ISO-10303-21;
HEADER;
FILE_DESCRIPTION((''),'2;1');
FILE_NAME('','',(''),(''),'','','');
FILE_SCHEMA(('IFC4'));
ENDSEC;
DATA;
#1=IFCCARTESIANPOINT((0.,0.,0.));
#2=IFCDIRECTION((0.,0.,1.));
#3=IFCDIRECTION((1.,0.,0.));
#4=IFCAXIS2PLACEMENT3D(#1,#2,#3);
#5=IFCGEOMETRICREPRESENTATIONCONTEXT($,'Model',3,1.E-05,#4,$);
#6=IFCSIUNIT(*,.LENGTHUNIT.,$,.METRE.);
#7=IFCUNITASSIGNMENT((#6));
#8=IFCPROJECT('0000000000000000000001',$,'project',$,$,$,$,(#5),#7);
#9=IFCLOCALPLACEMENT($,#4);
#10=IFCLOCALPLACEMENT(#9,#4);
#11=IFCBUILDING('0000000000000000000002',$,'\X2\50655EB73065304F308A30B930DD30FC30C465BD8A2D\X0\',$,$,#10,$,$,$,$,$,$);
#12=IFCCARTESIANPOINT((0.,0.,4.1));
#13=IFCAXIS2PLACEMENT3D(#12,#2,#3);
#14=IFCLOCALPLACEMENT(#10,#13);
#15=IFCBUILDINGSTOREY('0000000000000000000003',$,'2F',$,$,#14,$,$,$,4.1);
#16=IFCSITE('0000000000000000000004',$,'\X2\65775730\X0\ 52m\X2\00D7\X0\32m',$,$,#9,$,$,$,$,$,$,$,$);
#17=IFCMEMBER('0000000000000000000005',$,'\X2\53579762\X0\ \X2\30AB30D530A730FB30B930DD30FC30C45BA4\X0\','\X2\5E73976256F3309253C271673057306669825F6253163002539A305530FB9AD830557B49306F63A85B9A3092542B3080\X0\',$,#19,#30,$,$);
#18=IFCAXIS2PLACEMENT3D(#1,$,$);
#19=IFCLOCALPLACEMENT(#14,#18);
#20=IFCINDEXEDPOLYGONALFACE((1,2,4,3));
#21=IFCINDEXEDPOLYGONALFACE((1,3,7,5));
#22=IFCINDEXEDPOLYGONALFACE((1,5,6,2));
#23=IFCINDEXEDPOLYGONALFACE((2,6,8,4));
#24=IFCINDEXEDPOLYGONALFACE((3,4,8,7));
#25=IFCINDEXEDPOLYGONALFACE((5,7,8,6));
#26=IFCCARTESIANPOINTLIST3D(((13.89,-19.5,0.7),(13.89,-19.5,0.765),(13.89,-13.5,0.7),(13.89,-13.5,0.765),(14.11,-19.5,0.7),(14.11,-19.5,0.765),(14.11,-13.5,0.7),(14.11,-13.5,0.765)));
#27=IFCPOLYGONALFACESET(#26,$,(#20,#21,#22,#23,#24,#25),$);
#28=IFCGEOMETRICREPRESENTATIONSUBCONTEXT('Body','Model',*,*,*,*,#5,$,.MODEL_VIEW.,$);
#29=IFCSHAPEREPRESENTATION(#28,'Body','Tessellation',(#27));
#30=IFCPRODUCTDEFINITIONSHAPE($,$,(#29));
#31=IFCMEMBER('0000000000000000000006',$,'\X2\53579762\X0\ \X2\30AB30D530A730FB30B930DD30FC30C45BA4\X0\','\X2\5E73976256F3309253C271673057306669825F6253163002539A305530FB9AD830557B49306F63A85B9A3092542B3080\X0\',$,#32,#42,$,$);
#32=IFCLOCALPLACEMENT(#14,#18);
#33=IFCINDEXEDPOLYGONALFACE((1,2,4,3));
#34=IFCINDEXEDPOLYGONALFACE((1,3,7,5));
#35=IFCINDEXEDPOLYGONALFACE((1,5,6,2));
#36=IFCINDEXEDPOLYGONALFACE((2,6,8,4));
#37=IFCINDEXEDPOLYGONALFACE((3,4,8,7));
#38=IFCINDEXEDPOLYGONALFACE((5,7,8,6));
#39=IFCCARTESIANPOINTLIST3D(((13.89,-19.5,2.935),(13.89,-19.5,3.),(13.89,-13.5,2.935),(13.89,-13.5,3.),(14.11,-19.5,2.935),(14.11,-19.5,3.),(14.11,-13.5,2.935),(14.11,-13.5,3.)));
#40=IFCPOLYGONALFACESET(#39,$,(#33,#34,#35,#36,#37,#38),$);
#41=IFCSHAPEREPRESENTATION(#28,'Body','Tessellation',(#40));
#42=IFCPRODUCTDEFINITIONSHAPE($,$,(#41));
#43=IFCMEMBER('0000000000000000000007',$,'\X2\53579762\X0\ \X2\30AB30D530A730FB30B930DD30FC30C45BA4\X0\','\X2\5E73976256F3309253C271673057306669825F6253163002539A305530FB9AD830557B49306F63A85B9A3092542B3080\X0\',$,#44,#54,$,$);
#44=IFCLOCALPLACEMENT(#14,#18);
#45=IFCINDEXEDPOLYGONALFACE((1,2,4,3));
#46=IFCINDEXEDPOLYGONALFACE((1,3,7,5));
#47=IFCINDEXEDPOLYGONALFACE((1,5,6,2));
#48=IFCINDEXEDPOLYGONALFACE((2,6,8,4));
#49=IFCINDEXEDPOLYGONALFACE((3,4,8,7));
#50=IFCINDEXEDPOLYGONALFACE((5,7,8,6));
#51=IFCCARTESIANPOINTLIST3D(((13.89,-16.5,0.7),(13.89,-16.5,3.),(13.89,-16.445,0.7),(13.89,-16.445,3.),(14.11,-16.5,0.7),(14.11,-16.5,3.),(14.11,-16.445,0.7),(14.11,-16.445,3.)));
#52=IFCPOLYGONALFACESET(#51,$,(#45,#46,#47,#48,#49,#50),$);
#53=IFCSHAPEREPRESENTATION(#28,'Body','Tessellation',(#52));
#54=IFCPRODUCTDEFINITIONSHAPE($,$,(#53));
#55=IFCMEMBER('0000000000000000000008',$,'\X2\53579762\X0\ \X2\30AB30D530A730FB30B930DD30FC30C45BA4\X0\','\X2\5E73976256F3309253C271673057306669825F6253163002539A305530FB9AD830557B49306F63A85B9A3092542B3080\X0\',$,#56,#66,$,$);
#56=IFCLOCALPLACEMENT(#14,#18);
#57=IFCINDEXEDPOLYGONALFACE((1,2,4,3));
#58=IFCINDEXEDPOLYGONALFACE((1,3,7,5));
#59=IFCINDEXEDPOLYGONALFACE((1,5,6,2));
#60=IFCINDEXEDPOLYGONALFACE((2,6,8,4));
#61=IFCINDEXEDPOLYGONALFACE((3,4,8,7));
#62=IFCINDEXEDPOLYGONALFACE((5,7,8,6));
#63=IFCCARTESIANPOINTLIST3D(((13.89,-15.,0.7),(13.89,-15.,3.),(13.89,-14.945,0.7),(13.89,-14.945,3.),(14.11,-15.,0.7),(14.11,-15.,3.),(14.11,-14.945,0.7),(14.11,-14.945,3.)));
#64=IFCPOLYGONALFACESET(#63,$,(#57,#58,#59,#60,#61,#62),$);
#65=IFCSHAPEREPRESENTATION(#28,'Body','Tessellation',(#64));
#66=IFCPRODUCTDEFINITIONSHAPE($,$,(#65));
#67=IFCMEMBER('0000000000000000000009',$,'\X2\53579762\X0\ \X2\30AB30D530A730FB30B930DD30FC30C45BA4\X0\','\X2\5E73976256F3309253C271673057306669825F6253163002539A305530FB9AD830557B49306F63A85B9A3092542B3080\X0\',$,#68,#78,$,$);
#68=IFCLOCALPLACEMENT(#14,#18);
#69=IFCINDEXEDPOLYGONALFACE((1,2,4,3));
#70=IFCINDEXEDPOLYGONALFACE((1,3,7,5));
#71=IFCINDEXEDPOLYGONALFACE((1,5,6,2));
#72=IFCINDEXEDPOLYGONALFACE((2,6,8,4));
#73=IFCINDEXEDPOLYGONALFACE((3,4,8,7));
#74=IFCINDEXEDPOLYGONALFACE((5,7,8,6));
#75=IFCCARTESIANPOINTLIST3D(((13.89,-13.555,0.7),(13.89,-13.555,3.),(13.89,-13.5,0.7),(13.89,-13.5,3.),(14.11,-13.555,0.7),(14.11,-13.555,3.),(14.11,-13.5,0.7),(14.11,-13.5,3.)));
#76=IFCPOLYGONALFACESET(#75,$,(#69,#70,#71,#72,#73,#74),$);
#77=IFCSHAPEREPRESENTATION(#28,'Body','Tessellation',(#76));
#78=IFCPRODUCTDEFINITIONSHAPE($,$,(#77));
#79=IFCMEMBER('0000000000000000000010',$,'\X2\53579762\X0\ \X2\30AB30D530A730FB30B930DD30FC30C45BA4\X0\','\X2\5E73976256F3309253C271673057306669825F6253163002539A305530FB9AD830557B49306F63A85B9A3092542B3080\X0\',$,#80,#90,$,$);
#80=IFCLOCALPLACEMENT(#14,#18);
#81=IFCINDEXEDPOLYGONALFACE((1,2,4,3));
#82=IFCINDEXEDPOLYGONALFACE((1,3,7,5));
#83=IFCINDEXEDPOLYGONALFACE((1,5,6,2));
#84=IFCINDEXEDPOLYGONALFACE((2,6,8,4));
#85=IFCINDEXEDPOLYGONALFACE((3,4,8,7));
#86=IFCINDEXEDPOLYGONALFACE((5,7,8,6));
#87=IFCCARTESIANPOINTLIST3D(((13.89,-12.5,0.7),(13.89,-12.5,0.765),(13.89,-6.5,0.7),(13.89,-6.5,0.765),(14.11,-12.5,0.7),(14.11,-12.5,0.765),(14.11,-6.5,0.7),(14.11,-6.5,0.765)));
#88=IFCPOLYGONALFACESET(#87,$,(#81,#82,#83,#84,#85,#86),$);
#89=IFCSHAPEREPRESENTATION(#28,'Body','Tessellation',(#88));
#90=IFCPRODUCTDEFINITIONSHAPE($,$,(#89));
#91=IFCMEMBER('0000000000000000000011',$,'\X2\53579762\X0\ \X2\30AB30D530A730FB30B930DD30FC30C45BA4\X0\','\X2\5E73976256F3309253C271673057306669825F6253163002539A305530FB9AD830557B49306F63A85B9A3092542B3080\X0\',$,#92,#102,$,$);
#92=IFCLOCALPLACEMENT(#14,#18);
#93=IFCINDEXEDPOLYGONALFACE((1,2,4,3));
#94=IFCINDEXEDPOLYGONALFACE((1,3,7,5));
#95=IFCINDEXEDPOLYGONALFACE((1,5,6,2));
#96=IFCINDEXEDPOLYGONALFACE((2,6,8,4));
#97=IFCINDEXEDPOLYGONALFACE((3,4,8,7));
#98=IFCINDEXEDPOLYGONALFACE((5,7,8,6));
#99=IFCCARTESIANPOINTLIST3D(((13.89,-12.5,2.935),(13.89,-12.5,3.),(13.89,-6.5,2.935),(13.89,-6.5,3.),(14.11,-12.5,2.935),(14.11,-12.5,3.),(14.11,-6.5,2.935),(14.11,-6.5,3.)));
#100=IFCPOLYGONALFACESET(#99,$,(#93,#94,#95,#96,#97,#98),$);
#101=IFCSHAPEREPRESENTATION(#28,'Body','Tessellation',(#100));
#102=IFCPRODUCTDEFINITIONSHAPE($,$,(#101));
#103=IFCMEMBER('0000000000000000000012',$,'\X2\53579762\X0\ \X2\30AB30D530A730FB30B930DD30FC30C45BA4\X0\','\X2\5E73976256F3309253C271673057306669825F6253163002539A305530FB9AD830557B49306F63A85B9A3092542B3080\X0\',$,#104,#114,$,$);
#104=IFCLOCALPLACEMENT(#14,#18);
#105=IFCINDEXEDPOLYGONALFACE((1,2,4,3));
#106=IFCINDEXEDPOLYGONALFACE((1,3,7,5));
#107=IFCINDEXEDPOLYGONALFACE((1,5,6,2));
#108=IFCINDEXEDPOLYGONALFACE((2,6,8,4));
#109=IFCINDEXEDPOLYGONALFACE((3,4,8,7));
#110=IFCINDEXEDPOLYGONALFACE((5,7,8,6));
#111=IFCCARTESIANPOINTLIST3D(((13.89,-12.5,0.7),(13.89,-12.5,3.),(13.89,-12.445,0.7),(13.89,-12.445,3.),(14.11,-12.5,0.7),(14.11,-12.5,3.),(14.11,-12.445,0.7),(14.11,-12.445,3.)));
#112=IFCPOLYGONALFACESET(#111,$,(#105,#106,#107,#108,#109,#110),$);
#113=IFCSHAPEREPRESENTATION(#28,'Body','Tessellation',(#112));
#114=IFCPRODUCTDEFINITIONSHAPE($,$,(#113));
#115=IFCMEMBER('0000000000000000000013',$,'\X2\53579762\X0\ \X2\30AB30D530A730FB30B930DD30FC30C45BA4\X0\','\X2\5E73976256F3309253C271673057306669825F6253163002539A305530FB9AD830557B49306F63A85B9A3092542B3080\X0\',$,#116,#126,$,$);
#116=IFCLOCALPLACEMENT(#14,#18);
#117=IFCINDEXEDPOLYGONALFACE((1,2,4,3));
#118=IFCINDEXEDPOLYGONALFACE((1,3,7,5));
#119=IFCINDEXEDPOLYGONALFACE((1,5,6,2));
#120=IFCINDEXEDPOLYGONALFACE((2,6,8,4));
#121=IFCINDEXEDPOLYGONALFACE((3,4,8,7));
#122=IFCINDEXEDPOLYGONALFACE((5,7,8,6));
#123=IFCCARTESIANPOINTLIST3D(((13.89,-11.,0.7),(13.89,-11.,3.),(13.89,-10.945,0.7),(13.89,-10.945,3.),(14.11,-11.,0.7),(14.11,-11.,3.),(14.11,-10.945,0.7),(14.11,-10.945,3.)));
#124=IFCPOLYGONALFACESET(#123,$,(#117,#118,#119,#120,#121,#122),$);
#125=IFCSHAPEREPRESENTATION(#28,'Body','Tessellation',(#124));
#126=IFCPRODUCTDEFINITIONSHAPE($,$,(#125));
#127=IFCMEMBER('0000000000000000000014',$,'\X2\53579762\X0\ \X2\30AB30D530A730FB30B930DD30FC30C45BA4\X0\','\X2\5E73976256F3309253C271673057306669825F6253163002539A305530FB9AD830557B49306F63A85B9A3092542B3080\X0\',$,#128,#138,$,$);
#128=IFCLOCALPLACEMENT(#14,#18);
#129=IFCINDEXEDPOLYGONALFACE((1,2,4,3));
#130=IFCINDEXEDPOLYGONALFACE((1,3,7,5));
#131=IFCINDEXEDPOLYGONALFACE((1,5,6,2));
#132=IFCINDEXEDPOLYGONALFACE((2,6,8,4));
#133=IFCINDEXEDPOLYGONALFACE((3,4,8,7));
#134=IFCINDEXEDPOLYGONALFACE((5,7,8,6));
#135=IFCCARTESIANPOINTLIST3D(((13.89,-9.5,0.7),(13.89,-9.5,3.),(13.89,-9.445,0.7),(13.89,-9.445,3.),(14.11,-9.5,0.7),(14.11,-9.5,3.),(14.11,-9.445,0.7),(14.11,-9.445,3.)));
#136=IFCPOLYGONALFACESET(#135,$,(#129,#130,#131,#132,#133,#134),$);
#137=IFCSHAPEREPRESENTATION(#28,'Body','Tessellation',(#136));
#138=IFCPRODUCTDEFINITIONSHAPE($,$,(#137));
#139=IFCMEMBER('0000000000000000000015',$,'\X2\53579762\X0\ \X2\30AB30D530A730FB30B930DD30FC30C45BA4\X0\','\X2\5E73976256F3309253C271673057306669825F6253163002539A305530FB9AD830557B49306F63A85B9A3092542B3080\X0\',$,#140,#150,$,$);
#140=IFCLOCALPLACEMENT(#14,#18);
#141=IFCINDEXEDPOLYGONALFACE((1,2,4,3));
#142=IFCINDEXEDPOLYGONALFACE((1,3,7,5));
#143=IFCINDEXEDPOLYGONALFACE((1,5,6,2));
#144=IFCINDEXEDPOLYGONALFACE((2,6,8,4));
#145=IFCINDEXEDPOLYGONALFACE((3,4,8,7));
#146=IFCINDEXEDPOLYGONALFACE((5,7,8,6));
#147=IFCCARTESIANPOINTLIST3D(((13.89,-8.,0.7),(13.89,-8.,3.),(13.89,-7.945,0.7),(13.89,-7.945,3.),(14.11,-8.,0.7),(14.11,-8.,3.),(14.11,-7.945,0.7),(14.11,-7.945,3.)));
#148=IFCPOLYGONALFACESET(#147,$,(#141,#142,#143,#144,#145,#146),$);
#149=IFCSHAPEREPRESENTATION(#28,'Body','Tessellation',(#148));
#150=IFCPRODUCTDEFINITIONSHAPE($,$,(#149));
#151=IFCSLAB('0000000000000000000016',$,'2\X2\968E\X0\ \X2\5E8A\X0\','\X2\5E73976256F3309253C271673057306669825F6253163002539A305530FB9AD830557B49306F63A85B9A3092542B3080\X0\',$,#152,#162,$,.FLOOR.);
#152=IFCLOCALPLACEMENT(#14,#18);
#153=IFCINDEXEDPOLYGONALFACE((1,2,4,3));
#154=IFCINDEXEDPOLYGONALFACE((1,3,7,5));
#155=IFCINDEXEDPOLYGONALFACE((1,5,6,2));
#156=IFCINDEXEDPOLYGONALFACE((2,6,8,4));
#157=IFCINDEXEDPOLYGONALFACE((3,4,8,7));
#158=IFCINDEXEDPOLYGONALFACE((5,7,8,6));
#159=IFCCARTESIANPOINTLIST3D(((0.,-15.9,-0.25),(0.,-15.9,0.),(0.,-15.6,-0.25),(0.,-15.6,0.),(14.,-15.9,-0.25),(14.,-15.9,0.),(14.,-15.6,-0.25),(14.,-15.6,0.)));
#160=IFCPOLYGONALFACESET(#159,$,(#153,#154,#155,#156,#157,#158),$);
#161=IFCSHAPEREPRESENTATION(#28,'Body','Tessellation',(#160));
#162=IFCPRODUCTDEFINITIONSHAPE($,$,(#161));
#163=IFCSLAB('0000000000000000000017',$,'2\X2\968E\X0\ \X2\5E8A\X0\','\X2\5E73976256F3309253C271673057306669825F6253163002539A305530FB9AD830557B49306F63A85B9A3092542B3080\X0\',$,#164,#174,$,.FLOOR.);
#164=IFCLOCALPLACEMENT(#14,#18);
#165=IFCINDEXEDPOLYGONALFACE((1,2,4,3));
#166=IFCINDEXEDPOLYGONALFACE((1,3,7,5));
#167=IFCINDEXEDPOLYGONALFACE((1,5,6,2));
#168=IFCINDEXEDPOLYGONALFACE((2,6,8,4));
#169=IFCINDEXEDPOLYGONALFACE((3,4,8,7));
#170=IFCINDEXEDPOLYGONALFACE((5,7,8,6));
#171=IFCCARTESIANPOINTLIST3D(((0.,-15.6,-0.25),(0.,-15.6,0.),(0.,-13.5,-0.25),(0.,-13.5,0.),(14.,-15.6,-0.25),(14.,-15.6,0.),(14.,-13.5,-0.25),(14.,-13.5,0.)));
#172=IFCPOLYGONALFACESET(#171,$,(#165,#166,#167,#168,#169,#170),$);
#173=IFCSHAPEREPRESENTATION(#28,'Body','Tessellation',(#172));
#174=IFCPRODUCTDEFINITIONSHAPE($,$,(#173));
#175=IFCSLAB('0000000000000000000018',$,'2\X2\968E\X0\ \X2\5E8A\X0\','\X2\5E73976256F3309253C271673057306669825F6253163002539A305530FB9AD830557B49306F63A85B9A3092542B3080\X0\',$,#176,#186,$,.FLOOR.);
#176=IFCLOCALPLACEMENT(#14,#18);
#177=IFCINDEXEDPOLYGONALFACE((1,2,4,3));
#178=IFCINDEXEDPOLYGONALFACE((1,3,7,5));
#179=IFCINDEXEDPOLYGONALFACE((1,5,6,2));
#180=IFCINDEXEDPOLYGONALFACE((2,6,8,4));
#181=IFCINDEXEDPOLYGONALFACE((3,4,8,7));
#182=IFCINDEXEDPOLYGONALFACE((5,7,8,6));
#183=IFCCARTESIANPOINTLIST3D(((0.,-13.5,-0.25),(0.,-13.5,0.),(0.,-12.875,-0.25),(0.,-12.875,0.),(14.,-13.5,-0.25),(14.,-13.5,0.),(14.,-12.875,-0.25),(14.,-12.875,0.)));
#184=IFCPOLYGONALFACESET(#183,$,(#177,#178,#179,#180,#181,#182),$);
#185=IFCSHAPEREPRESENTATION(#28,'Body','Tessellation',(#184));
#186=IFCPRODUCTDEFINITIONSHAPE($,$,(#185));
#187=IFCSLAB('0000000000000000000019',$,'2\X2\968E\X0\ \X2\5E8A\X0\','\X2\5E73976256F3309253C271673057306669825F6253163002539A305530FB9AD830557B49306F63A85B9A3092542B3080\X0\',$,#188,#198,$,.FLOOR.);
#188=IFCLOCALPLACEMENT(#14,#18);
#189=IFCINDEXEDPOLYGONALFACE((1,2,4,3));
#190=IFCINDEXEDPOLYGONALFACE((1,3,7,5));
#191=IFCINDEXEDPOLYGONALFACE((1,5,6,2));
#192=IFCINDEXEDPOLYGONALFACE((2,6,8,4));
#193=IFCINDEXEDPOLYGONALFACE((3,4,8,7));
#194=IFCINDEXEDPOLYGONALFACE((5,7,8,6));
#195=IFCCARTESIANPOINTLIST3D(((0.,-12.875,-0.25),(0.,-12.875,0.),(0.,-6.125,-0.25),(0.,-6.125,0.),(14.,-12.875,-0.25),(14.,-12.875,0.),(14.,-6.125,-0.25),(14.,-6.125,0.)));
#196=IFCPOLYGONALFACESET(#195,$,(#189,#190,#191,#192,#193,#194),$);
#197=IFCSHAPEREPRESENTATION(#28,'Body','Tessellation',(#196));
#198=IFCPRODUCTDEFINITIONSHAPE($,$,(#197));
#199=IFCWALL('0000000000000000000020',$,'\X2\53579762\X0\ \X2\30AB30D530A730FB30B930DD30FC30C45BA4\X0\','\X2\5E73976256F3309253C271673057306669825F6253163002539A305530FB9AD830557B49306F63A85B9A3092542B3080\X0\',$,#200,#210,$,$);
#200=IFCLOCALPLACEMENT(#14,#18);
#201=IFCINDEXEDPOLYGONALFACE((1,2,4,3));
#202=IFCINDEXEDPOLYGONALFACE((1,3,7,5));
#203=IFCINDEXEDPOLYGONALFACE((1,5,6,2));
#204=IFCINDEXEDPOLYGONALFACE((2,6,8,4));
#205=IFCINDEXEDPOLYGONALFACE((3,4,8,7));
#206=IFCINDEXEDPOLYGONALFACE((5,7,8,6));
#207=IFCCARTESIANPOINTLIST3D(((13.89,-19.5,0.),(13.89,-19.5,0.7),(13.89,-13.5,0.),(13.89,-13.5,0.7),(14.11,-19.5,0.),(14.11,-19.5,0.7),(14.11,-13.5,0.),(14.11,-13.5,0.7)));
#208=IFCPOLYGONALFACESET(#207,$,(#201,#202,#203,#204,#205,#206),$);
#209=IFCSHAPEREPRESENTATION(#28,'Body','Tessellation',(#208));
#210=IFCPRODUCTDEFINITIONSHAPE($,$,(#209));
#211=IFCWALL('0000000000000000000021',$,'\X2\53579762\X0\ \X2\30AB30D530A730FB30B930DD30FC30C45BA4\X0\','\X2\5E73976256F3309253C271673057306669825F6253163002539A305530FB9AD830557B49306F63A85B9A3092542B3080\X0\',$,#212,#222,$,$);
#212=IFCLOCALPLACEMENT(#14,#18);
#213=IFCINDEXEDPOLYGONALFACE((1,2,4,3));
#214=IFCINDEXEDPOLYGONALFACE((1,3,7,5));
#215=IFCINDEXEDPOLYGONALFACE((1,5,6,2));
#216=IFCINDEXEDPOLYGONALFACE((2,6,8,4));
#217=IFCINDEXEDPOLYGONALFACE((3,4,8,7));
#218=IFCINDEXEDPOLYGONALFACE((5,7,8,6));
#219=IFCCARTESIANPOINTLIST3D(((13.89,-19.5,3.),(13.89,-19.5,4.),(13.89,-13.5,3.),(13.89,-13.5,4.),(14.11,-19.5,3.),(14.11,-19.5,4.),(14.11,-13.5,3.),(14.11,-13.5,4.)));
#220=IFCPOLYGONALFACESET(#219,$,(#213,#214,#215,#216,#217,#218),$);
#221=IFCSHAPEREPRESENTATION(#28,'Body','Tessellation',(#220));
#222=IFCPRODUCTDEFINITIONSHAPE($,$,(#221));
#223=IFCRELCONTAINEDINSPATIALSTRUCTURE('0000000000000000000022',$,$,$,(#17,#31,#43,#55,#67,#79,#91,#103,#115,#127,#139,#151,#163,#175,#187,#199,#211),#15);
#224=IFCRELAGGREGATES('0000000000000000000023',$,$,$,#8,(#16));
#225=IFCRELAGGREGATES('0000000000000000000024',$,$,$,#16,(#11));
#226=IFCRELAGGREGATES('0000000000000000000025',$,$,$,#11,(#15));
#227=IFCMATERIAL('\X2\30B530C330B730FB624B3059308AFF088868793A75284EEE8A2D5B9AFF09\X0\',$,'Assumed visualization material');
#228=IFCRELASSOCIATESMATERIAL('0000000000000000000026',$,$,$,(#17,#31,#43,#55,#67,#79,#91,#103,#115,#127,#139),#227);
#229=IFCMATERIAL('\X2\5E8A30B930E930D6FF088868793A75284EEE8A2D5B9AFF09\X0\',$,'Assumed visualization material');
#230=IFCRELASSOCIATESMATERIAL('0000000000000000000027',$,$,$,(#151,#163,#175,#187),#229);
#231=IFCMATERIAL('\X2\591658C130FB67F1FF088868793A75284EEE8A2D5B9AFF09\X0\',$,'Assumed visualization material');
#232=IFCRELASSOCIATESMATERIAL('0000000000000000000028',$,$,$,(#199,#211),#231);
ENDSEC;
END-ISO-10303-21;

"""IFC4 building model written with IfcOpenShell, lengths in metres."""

from ifc_helpers import new_model, si_unit, frame, origin_with_axes, place, context, subcontext, project, spatial, rectangle, extrude, material, element, save


model = new_model("IFC4")

# Units and contexts
model_context = context("Model", 3, precision=1e-05, world=origin_with_axes())
body_context = subcontext(model_context, "Body", "Model", "MODEL_VIEW")
ifc_project = project(units=[si_unit("LENGTHUNIT", "METRE")], contexts=[model_context])

# Site, building, storey
site_placement = place(None, origin_with_axes())
site = spatial("IfcSite", under=ifc_project, at=site_placement, Name="敷地 52m×32m")
building_placement = place(site_placement, origin_with_axes())
building = spatial("IfcBuilding", under=site, at=building_placement, Name="健康づくりスポーツ施設")
storey_placement = place(building_placement, frame((0.0, 0.0, 4.1), z_axis=(0.0, 0.0, 1.0), x_axis=(1.0, 0.0, 0.0)))
storey = spatial("IfcBuildingStorey", under=building, at=storey_placement, Name="2F", Elevation=4.1)

# Members
ifc_material_1 = material(Name="サッシ・手すり（表示用仮設定）", Category="Assumed visualization material")
for number, where, z_axis, x_axis, name in (
    (1, (14.0, -16.5, 0.7), (0.0, 0.0, 1.0), (1.0, 0.0, 0.0), "南面 カフェ・スポーツ室"),
    (2, (14.0, -16.5, 2.935), (0.0, 0.0, 1.0), (1.0, 0.0, 0.0), "南面 カフェ・スポーツ室"),
):
    element("IfcMember", number, at=place(storey_placement, frame(where, z_axis=z_axis, x_axis=x_axis)), inside=storey, material=ifc_material_1, Name=name, Description="平面図を参照して概形化。厚さ・高さ等は推定を含む", context=body_context, shape_type="SweptSolid", body=[
        extrude(rectangle(XDim=0.22, YDim=6.0), origin_with_axes(), (0.0, 0.0, 1.0), 0.065),
    ])
member_placement = place(storey_placement, frame((14.0, -16.4725, 0.7), z_axis=(0.0, 0.0, 1.0), x_axis=(1.0, 0.0, 0.0)))
element("IfcMember", 3, at=member_placement, inside=storey, material=ifc_material_1, Name="南面 カフェ・スポーツ室", Description="平面図を参照して概形化。厚さ・高さ等は推定を含む", context=body_context, shape_type="SweptSolid", body=[
    extrude(rectangle(XDim=0.22, YDim=0.055), origin_with_axes(), (0.0, 0.0, 1.0), 2.3),
])
for number, where, z_axis, x_axis, name in (
    (4, (14.0, -14.9725, 0.7), (0.0, 0.0, 1.0), (1.0, 0.0, 0.0), "南面 カフェ・スポーツ室"),
    (5, (14.0, -13.5275, 0.7), (0.0, 0.0, 1.0), (1.0, 0.0, 0.0), "南面 カフェ・スポーツ室"),
):
    element("IfcMember", number, at=place(storey_placement, frame(where, z_axis=z_axis, x_axis=x_axis)), inside=storey, material=ifc_material_1, Name=name, Description="平面図を参照して概形化。厚さ・高さ等は推定を含む", context=body_context, shape_type="SweptSolid", body=[
        extrude(rectangle(XDim=0.22, YDim=0.055), origin_with_axes(), (0.0, 0.0, 1.0), 2.3),
    ])
for number, where, z_axis, x_axis, name in (
    (6, (14.0, -9.5, 0.7), (0.0, 0.0, 1.0), (1.0, 0.0, 0.0), "南面 カフェ・スポーツ室"),
    (7, (14.0, -9.5, 2.935), (0.0, 0.0, 1.0), (1.0, 0.0, 0.0), "南面 カフェ・スポーツ室"),
):
    element("IfcMember", number, at=place(storey_placement, frame(where, z_axis=z_axis, x_axis=x_axis)), inside=storey, material=ifc_material_1, Name=name, Description="平面図を参照して概形化。厚さ・高さ等は推定を含む", context=body_context, shape_type="SweptSolid", body=[
        extrude(rectangle(XDim=0.22, YDim=6.0), origin_with_axes(), (0.0, 0.0, 1.0), 0.065),
    ])
for number, where, z_axis, x_axis, name in (
    (8, (14.0, -12.4725, 0.7), (0.0, 0.0, 1.0), (1.0, 0.0, 0.0), "南面 カフェ・スポーツ室"),
    (9, (14.0, -10.9725, 0.7), (0.0, 0.0, 1.0), (1.0, 0.0, 0.0), "南面 カフェ・スポーツ室"),
    (10, (14.0, -9.4725, 0.7), (0.0, 0.0, 1.0), (1.0, 0.0, 0.0), "南面 カフェ・スポーツ室"),
    (11, (14.0, -7.9725, 0.7), (0.0, 0.0, 1.0), (1.0, 0.0, 0.0), "南面 カフェ・スポーツ室"),
):
    element("IfcMember", number, at=place(storey_placement, frame(where, z_axis=z_axis, x_axis=x_axis)), inside=storey, material=ifc_material_1, Name=name, Description="平面図を参照して概形化。厚さ・高さ等は推定を含む", context=body_context, shape_type="SweptSolid", body=[
        extrude(rectangle(XDim=0.22, YDim=0.055), origin_with_axes(), (0.0, 0.0, 1.0), 2.3),
    ])

# Slabs
ifc_material_2 = material(Name="床スラブ（表示用仮設定）", Category="Assumed visualization material")
slab_1_placement = place(storey_placement, frame((7.0, -15.75, -0.25), z_axis=(0.0, 0.0, 1.0), x_axis=(1.0, 0.0, 0.0)))
element("IfcSlab", 12, at=slab_1_placement, inside=storey, material=ifc_material_2, Name="2階 床", Description="平面図を参照して概形化。厚さ・高さ等は推定を含む", PredefinedType="FLOOR", context=body_context, shape_type="SweptSolid", body=[
    extrude(rectangle(XDim=14.0, YDim=0.3), origin_with_axes(), (0.0, 0.0, 1.0), 0.25),
])
slab_2_placement = place(storey_placement, frame((7.0, -14.55, -0.25), z_axis=(0.0, 0.0, 1.0), x_axis=(1.0, 0.0, 0.0)))
element("IfcSlab", 13, at=slab_2_placement, inside=storey, material=ifc_material_2, Name="2階 床", Description="平面図を参照して概形化。厚さ・高さ等は推定を含む", PredefinedType="FLOOR", context=body_context, shape_type="SweptSolid", body=[
    extrude(rectangle(XDim=14.0, YDim=2.1), origin_with_axes(), (0.0, 0.0, 1.0), 0.25),
])
slab_3_placement = place(storey_placement, frame((7.0, -13.1875, -0.25), z_axis=(0.0, 0.0, 1.0), x_axis=(1.0, 0.0, 0.0)))
element("IfcSlab", 14, at=slab_3_placement, inside=storey, material=ifc_material_2, Name="2階 床", Description="平面図を参照して概形化。厚さ・高さ等は推定を含む", PredefinedType="FLOOR", context=body_context, shape_type="SweptSolid", body=[
    extrude(rectangle(XDim=14.0, YDim=0.625), origin_with_axes(), (0.0, 0.0, 1.0), 0.25),
])
slab_4_placement = place(storey_placement, frame((7.0, -9.5, -0.25), z_axis=(0.0, 0.0, 1.0), x_axis=(1.0, 0.0, 0.0)))
element("IfcSlab", 15, at=slab_4_placement, inside=storey, material=ifc_material_2, Name="2階 床", Description="平面図を参照して概形化。厚さ・高さ等は推定を含む", PredefinedType="FLOOR", context=body_context, shape_type="SweptSolid", body=[
    extrude(rectangle(XDim=14.0, YDim=6.75), origin_with_axes(), (0.0, 0.0, 1.0), 0.25),
])

# Walls
ifc_material_3 = material(Name="外壁・柱（表示用仮設定）", Category="Assumed visualization material")
wall_1_placement = place(storey_placement, frame((14.0, -16.5, 0.0), z_axis=(0.0, 0.0, 1.0), x_axis=(1.0, 0.0, 0.0)))
element("IfcWall", 16, at=wall_1_placement, inside=storey, material=ifc_material_3, Name="南面 カフェ・スポーツ室", Description="平面図を参照して概形化。厚さ・高さ等は推定を含む", context=body_context, shape_type="SweptSolid", body=[
    extrude(rectangle(XDim=0.22, YDim=6.0), origin_with_axes(), (0.0, 0.0, 1.0), 0.7),
])
wall_2_placement = place(storey_placement, frame((14.0, -16.5, 3.0), z_axis=(0.0, 0.0, 1.0), x_axis=(1.0, 0.0, 0.0)))
element("IfcWall", 17, at=wall_2_placement, inside=storey, material=ifc_material_3, Name="南面 カフェ・スポーツ室", Description="平面図を参照して概形化。厚さ・高さ等は推定を含む", context=body_context, shape_type="SweptSolid", body=[
    extrude(rectangle(XDim=0.22, YDim=6.0), origin_with_axes(), (0.0, 0.0, 1.0), 1.0),
])

save(model, "model.ifc")
